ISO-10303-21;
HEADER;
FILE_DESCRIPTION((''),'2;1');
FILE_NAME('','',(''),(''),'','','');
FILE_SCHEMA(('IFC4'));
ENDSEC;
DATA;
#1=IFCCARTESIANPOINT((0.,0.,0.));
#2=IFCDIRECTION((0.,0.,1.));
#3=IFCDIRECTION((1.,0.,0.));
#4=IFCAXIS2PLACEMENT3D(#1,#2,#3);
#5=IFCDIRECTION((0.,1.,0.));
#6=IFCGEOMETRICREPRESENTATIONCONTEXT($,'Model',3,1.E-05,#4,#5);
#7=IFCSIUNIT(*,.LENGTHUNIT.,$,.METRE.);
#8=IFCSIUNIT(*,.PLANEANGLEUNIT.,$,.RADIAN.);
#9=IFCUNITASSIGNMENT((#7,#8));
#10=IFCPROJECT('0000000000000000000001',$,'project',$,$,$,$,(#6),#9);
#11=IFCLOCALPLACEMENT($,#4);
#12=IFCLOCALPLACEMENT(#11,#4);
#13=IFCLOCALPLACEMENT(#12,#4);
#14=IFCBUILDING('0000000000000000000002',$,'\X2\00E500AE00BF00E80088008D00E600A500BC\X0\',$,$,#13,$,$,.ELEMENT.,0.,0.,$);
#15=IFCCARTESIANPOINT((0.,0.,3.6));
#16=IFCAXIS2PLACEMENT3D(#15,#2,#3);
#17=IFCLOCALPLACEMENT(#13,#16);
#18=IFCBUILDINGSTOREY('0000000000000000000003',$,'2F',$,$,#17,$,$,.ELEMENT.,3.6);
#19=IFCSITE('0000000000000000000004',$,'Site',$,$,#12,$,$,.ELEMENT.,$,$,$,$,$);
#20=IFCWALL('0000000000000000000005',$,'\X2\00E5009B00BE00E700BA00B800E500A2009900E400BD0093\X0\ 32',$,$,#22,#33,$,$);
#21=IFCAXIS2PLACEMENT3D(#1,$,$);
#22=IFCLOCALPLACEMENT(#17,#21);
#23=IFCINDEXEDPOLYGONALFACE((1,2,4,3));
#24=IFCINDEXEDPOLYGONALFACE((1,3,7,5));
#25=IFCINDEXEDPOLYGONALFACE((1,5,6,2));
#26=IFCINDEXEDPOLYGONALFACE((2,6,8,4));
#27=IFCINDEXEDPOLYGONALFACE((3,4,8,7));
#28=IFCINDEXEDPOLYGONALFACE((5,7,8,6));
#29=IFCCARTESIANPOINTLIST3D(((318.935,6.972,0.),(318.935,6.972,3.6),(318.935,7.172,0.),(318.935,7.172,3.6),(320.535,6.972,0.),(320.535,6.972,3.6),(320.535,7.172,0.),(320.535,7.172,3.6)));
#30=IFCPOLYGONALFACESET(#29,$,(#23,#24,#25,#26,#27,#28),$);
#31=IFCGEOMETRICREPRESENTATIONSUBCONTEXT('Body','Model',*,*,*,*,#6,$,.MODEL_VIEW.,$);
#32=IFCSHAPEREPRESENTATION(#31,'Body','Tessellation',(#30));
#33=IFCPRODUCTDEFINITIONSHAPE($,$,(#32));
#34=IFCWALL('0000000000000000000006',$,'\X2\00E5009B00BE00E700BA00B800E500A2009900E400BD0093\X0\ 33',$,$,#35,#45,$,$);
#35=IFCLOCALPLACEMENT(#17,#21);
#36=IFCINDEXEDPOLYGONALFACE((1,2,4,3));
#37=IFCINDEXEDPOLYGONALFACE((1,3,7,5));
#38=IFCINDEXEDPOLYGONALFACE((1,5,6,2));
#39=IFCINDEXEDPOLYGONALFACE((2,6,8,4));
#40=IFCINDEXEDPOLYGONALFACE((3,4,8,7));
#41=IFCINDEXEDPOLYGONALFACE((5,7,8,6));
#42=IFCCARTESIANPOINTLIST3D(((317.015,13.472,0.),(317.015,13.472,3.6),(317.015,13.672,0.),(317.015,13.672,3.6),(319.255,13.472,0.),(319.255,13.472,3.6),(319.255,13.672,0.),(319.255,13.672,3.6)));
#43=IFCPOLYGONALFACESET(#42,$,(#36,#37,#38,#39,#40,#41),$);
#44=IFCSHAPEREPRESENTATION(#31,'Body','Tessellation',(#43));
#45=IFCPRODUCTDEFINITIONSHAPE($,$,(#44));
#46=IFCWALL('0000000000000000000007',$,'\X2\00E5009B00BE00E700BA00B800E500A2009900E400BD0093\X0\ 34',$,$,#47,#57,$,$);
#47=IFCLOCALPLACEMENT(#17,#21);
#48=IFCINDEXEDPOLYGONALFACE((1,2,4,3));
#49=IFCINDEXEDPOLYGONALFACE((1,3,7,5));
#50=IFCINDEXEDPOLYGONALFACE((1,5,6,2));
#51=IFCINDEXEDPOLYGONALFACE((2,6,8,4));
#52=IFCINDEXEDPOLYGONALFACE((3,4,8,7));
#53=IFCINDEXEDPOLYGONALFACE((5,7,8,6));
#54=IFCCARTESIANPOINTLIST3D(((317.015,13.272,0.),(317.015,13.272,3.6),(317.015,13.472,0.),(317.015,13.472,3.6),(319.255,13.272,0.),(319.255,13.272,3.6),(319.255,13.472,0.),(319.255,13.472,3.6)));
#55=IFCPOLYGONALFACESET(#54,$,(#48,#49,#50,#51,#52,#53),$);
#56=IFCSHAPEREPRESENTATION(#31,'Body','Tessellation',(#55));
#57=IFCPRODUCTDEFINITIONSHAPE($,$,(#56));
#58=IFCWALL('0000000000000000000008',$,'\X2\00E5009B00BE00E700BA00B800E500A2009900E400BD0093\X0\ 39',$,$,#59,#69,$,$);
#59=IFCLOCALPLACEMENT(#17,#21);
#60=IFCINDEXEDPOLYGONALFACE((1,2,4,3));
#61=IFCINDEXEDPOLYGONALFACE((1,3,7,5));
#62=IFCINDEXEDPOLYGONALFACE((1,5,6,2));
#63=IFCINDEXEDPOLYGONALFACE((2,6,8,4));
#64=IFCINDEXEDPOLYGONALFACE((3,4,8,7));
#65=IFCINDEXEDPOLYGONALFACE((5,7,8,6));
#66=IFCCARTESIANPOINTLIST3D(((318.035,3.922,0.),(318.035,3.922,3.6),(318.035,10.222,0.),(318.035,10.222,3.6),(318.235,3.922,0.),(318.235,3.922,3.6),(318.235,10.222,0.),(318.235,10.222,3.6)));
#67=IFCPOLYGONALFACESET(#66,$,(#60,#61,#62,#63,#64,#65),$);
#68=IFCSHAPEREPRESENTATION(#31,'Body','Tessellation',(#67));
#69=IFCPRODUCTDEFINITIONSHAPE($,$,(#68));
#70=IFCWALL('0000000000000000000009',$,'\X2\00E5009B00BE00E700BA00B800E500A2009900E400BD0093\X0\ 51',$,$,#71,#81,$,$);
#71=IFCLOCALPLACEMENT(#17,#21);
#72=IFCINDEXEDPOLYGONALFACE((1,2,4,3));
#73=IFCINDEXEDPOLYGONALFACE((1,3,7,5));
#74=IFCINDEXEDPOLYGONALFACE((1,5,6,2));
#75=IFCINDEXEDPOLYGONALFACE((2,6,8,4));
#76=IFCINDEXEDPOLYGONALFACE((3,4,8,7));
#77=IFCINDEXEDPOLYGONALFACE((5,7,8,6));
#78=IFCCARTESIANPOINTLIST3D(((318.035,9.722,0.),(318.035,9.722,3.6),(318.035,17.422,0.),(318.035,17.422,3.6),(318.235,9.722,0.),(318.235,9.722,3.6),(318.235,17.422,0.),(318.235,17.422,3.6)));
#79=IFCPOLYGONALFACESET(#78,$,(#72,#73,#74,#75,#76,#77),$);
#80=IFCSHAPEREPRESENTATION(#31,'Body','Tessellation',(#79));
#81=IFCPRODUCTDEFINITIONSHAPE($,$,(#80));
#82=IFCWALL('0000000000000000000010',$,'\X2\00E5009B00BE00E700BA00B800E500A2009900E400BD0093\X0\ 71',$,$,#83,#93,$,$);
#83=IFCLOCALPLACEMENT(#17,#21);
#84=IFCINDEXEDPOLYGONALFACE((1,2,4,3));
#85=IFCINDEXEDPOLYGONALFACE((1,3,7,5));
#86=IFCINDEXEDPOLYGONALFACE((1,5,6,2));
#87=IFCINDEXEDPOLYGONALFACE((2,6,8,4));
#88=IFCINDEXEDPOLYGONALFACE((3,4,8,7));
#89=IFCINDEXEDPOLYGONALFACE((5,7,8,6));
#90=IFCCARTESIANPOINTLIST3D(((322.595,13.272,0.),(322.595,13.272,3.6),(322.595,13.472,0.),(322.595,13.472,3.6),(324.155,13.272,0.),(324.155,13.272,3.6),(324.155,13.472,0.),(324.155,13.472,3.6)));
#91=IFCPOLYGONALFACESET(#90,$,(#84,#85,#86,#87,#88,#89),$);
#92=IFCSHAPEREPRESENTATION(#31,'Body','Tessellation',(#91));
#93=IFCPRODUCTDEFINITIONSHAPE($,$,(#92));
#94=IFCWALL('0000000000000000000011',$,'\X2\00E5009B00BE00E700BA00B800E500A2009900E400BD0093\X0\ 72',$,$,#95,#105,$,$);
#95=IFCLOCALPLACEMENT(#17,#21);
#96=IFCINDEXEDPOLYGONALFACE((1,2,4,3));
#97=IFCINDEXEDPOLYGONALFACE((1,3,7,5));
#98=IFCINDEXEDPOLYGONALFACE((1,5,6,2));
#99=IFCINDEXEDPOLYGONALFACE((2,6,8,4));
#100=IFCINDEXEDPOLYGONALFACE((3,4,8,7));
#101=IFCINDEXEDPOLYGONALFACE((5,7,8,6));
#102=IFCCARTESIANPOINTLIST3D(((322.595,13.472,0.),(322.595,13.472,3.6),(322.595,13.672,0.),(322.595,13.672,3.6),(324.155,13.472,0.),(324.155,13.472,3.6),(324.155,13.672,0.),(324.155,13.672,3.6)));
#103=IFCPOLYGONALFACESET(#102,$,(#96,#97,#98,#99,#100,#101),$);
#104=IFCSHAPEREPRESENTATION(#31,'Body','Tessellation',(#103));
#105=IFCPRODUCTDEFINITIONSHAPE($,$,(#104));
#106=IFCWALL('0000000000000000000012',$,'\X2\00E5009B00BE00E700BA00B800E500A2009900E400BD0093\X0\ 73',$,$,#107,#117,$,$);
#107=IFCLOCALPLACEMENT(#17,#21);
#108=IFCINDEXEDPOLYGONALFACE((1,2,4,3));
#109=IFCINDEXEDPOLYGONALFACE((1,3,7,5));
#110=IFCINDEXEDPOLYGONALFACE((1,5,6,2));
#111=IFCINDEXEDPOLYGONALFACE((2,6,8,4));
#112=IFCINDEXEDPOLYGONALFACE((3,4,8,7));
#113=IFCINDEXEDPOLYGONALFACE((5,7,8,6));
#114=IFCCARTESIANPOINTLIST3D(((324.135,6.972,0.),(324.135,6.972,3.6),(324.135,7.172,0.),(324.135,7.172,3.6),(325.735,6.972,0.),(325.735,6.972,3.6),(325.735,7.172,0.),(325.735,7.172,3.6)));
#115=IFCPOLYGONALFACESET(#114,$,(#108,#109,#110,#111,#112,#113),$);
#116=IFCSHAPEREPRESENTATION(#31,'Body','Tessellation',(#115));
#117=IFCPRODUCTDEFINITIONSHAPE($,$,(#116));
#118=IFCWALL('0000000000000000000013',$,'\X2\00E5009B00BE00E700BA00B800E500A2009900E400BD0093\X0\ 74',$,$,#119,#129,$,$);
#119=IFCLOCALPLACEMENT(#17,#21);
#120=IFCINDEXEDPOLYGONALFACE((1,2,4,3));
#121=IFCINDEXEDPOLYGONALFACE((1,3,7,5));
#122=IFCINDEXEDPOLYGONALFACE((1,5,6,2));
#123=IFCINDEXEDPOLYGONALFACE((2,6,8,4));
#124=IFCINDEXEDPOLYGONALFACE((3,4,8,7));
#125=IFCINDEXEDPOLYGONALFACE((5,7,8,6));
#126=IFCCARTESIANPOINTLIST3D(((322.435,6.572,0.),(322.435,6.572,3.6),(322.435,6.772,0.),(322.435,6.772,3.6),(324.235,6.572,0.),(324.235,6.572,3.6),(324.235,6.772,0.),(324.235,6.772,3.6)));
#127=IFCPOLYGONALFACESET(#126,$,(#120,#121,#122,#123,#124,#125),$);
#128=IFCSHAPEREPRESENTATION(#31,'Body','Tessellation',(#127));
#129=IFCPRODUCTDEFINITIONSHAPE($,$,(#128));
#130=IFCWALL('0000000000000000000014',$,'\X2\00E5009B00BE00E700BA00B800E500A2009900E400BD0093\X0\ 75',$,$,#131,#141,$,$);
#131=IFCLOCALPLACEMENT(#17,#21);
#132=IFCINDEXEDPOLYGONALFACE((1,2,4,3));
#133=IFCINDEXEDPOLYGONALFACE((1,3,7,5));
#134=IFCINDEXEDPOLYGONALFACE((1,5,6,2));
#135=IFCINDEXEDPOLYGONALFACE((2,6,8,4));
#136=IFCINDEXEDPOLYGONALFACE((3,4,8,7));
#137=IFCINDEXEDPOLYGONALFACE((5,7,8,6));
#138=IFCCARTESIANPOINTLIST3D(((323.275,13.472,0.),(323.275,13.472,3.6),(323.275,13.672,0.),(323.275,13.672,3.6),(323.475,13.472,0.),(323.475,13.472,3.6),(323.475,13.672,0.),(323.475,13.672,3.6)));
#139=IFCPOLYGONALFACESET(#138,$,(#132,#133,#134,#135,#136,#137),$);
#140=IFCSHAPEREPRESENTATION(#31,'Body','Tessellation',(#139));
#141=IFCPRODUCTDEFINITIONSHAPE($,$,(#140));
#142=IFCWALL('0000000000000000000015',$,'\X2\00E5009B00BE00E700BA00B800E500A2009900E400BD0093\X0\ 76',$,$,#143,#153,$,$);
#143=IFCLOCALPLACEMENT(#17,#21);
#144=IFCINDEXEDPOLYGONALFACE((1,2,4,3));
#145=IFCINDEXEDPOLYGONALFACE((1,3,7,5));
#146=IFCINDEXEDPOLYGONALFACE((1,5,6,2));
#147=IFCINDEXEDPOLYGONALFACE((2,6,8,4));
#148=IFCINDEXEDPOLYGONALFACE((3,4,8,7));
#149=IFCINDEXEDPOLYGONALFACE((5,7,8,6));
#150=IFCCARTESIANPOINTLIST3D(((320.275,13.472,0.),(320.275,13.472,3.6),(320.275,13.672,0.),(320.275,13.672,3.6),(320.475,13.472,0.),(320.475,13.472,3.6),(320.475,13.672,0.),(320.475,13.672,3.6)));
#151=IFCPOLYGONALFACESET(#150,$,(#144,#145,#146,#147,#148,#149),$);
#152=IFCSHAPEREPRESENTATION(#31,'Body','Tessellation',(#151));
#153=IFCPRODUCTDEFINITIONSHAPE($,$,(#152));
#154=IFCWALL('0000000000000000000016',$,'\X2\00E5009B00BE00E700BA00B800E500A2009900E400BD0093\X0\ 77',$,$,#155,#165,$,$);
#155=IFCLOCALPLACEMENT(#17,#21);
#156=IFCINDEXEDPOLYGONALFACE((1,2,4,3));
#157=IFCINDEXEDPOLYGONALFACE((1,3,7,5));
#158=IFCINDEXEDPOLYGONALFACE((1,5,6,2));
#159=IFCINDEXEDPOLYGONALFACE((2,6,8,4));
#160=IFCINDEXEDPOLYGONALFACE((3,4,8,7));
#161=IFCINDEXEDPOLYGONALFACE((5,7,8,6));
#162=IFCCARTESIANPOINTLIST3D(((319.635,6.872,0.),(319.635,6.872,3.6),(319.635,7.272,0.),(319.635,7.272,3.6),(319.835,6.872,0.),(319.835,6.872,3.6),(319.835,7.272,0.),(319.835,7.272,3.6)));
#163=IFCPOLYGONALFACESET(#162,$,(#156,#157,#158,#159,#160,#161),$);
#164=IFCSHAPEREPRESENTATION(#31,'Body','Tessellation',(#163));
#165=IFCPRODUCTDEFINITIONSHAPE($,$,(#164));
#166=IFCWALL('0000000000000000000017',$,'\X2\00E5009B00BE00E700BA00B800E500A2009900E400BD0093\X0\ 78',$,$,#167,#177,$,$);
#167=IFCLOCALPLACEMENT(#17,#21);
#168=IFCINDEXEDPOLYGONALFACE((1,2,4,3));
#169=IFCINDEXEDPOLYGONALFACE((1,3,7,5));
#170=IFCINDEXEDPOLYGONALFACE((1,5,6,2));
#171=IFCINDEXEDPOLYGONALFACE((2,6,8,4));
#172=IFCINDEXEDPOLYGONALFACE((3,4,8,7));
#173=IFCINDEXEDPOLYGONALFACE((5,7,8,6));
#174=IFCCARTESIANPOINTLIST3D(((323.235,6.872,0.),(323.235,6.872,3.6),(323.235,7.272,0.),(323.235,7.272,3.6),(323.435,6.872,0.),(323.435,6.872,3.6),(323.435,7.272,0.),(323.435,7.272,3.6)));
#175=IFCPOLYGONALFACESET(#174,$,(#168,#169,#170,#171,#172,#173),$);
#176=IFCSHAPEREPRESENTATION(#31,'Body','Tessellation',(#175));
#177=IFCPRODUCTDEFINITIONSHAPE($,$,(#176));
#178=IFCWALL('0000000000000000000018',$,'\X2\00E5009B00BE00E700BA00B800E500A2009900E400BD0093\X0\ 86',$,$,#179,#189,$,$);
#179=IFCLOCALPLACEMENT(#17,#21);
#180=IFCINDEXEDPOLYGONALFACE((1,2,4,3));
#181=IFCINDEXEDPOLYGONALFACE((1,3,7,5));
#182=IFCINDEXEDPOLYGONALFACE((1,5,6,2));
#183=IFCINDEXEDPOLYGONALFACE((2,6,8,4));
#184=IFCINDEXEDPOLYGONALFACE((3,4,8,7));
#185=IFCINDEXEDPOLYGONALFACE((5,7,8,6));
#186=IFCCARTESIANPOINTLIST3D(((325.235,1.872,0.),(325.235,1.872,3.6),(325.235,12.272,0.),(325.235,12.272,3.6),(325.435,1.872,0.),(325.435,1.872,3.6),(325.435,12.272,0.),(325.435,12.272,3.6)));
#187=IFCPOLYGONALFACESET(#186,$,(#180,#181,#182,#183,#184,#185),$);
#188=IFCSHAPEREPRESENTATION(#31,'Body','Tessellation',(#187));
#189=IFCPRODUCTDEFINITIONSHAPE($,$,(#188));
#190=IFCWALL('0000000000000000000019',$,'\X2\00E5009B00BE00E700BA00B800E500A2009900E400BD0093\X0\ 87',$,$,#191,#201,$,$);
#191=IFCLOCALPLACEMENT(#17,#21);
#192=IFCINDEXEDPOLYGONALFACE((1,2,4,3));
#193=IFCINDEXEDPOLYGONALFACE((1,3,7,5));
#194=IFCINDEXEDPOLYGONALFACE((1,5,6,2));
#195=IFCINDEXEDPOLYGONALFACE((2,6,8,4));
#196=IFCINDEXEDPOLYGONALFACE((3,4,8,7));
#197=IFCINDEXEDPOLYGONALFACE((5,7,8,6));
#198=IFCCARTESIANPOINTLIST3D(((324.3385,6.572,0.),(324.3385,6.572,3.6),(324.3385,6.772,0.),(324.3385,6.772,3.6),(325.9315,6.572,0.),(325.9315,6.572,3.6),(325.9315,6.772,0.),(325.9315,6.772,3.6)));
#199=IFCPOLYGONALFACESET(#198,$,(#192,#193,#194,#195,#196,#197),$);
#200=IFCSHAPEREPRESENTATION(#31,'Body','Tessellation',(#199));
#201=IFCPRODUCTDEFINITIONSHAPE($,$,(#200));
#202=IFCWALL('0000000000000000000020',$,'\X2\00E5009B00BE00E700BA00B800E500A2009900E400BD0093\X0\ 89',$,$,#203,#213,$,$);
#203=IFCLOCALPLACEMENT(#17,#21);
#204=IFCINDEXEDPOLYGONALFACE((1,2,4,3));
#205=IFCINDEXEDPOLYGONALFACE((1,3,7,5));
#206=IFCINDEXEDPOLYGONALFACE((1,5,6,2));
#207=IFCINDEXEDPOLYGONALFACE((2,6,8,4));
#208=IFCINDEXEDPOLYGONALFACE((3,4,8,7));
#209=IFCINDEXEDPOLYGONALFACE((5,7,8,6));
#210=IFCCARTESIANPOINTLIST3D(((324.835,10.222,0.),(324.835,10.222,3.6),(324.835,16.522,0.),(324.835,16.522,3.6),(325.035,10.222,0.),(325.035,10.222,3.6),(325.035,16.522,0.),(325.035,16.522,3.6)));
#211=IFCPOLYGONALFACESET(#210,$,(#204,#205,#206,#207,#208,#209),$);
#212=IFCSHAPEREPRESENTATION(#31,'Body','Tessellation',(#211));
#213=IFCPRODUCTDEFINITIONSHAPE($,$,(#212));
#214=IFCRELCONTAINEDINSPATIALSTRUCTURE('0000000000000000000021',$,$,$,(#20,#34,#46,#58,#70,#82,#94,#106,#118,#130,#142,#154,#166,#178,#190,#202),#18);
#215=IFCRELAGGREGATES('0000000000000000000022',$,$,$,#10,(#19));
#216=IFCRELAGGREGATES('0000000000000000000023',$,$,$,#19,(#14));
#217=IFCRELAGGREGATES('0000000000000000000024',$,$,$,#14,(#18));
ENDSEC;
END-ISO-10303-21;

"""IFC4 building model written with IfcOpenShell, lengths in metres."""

from ifc_helpers import new_model, si_unit, direction, frame, frame_2d, origin_with_axes, place, context, subcontext, project, spatial, rectangle, extrude, element, save


model = new_model("IFC4")

# Units and contexts
model_context = context("Model", 3, precision=1e-05, world=origin_with_axes(), true_north=direction((0.0, 1.0, 0.0)))
body_context = subcontext(model_context, "Body", "Model", "MODEL_VIEW")
ifc_project = project(units=[si_unit("LENGTHUNIT", "METRE"), si_unit("PLANEANGLEUNIT", "RADIAN")], contexts=[model_context])

# Site, building, storey
placement = place(None, origin_with_axes())
site_placement = place(placement, origin_with_axes())
site = spatial("IfcSite", under=ifc_project, at=site_placement, Name="Site", CompositionType="ELEMENT")
building_placement = place(site_placement, origin_with_axes())
building = spatial("IfcBuilding", under=site, at=building_placement, Name="å®¿è\u0088\u008dæ¥¼", CompositionType="ELEMENT", ElevationOfRefHeight=0.0, ElevationOfTerrain=0.0)
storey_placement = place(building_placement, frame((0.0, 0.0, 3.6), z_axis=(0.0, 0.0, 1.0), x_axis=(1.0, 0.0, 0.0)))
storey = spatial("IfcBuildingStorey", under=building, at=storey_placement, Name="2F", CompositionType="ELEMENT", Elevation=3.6)

# Walls
wall_1_placement = place(storey_placement, frame((319.735, 7.072, 0.0), z_axis=(0.0, 0.0, 1.0), x_axis=(-1.0, 0.0, 0.0)))
element("IfcWall", 1, at=wall_1_placement, inside=storey, Name="å\u009b¾çº¸å¢\u0099ä½\u0093 32", context=body_context, shape_type="SweptSolid", body=[
    extrude(rectangle(XDim=1.6, YDim=0.2, at=frame_2d((0.0, 0.0), x_axis=(1.0, 0.0, 0.0))), frame((0.0, 0.0, 0.0), z_axis=(0.0, 0.0, 1.0)), (0.0, 0.0, 1.0), 3.6),
])
for number, where, z_axis, x_axis, name in (
    (2, (318.135, 13.572, 0.0), (0.0, 0.0, 1.0), (1.0, 0.0, 0.0), "å\u009b¾çº¸å¢\u0099ä½\u0093 33"),
    (3, (318.135, 13.372, 0.0), (0.0, 0.0, 1.0), (1.0, 0.0, 0.0), "å\u009b¾çº¸å¢\u0099ä½\u0093 34"),
):
    element("IfcWall", number, at=place(storey_placement, frame(where, z_axis=z_axis, x_axis=x_axis)), inside=storey, Name=name, context=body_context, shape_type="SweptSolid", body=[
        extrude(rectangle(XDim=2.24, YDim=0.2, at=frame_2d((0.0, 0.0), x_axis=(1.0, 0.0, 0.0))), frame((0.0, 0.0, 0.0), z_axis=(0.0, 0.0, 1.0)), (0.0, 0.0, 1.0), 3.6),
    ])
wall_2_placement = place(storey_placement, frame((318.135, 7.072, 0.0), z_axis=(0.0, 0.0, 1.0), x_axis=(0.0, 1.0, 0.0)))
element("IfcWall", 4, at=wall_2_placement, inside=storey, Name="å\u009b¾çº¸å¢\u0099ä½\u0093 39", context=body_context, shape_type="SweptSolid", body=[
    extrude(rectangle(XDim=6.3, YDim=0.2, at=frame_2d((0.0, 0.0), x_axis=(1.0, 0.0, 0.0))), frame((0.0, 0.0, 0.0), z_axis=(0.0, 0.0, 1.0)), (0.0, 0.0, 1.0), 3.6),
])
wall_3_placement = place(storey_placement, frame((318.135, 13.572, 0.0), z_axis=(0.0, 0.0, 1.0), x_axis=(0.0, 1.0, 0.0)))
element("IfcWall", 5, at=wall_3_placement, inside=storey, Name="å\u009b¾çº¸å¢\u0099ä½\u0093 51", context=body_context, shape_type="SweptSolid", body=[
    extrude(rectangle(XDim=7.7, YDim=0.2, at=frame_2d((0.0, 0.0), x_axis=(1.0, 0.0, 0.0))), frame((0.0, 0.0, 0.0), z_axis=(0.0, 0.0, 1.0)), (0.0, 0.0, 1.0), 3.6),
])
for number, where, z_axis, x_axis, name in (
    (6, (323.375, 13.372, 0.0), (0.0, 0.0, 1.0), (1.0, 0.0, 0.0), "å\u009b¾çº¸å¢\u0099ä½\u0093 71"),
    (7, (323.375, 13.572, 0.0), (0.0, 0.0, 1.0), (1.0, 0.0, 0.0), "å\u009b¾çº¸å¢\u0099ä½\u0093 72"),
):
    element("IfcWall", number, at=place(storey_placement, frame(where, z_axis=z_axis, x_axis=x_axis)), inside=storey, Name=name, context=body_context, shape_type="SweptSolid", body=[
        extrude(rectangle(XDim=1.56, YDim=0.2, at=frame_2d((0.0, 0.0), x_axis=(1.0, 0.0, 0.0))), frame((0.0, 0.0, 0.0), z_axis=(0.0, 0.0, 1.0)), (0.0, 0.0, 1.0), 3.6),
    ])
wall_4_placement = place(storey_placement, frame((324.935, 7.072, 0.0), z_axis=(0.0, 0.0, 1.0), x_axis=(-1.0, 0.0, 0.0)))
element("IfcWall", 8, at=wall_4_placement, inside=storey, Name="å\u009b¾çº¸å¢\u0099ä½\u0093 73", context=body_context, shape_type="SweptSolid", body=[
    extrude(rectangle(XDim=1.6, YDim=0.2, at=frame_2d((0.0, 0.0), x_axis=(1.0, 0.0, 0.0))), frame((0.0, 0.0, 0.0), z_axis=(0.0, 0.0, 1.0)), (0.0, 0.0, 1.0), 3.6),
])
wall_5_placement = place(storey_placement, frame((323.335, 6.672, 0.0), z_axis=(0.0, 0.0, 1.0), x_axis=(1.0, 0.0, 0.0)))
element("IfcWall", 9, at=wall_5_placement, inside=storey, Name="å\u009b¾çº¸å¢\u0099ä½\u0093 74", context=body_context, shape_type="SweptSolid", body=[
    extrude(rectangle(XDim=1.8, YDim=0.2, at=frame_2d((0.0, 0.0), x_axis=(1.0, 0.0, 0.0))), frame((0.0, 0.0, 0.0), z_axis=(0.0, 0.0, 1.0)), (0.0, 0.0, 1.0), 3.6),
])
for number, where, z_axis, x_axis, name in (
    (10, (323.375, 13.572, 0.0), (0.0, 0.0, 1.0), (0.0, -1.0, 0.0), "å\u009b¾çº¸å¢\u0099ä½\u0093 75"),
    (11, (320.375, 13.572, 0.0), (0.0, 0.0, 1.0), (0.0, -1.0, 0.0), "å\u009b¾çº¸å¢\u0099ä½\u0093 76"),
):
    element("IfcWall", number, at=place(storey_placement, frame(where, z_axis=z_axis, x_axis=x_axis)), inside=storey, Name=name, context=body_context, shape_type="SweptSolid", body=[
        extrude(rectangle(XDim=0.2, YDim=0.2, at=frame_2d((0.0, 0.0), x_axis=(1.0, 0.0, 0.0))), frame((0.0, 0.0, 0.0), z_axis=(0.0, 0.0, 1.0)), (0.0, 0.0, 1.0), 3.6),
    ])
for number, where, z_axis, x_axis, name in (
    (12, (319.735, 7.072, 0.0), (0.0, 0.0, 1.0), (0.0, -1.0, 0.0), "å\u009b¾çº¸å¢\u0099ä½\u0093 77"),
    (13, (323.335, 7.072, 0.0), (0.0, 0.0, 1.0), (0.0, -1.0, 0.0), "å\u009b¾çº¸å¢\u0099ä½\u0093 78"),
):
    element("IfcWall", number, at=place(storey_placement, frame(where, z_axis=z_axis, x_axis=x_axis)), inside=storey, Name=name, context=body_context, shape_type="SweptSolid", body=[
        extrude(rectangle(XDim=0.4, YDim=0.2, at=frame_2d((0.0, 0.0), x_axis=(1.0, 0.0, 0.0))), frame((0.0, 0.0, 0.0), z_axis=(0.0, 0.0, 1.0)), (0.0, 0.0, 1.0), 3.6),
    ])
wall_6_placement = place(storey_placement, frame((325.335, 7.072, 0.0), z_axis=(0.0, 0.0, 1.0), x_axis=(0.0, 1.0, 0.0)))
element("IfcWall", 14, at=wall_6_placement, inside=storey, Name="å\u009b¾çº¸å¢\u0099ä½\u0093 86", context=body_context, shape_type="SweptSolid", body=[
    extrude(rectangle(XDim=10.4, YDim=0.2, at=frame_2d((0.0, 0.0), x_axis=(1.0, 0.0, 0.0))), frame((0.0, 0.0, 0.0), z_axis=(0.0, 0.0, 1.0)), (0.0, 0.0, 1.0), 3.6),
])
wall_7_placement = place(storey_placement, frame((325.135, 6.672, 0.0), z_axis=(0.0, 0.0, 1.0), x_axis=(1.0, 0.0, 0.0)))
element("IfcWall", 15, at=wall_7_placement, inside=storey, Name="å\u009b¾çº¸å¢\u0099ä½\u0093 87", context=body_context, shape_type="SweptSolid", body=[
    extrude(rectangle(XDim=1.593, YDim=0.2, at=frame_2d((0.0, 0.0), x_axis=(1.0, 0.0, 0.0))), frame((0.0, 0.0, 0.0), z_axis=(0.0, 0.0, 1.0)), (0.0, 0.0, 1.0), 3.6),
])
wall_8_placement = place(storey_placement, frame((324.935, 13.372, 0.0), z_axis=(0.0, 0.0, 1.0), x_axis=(0.0, -1.0, 0.0)))
element("IfcWall", 16, at=wall_8_placement, inside=storey, Name="å\u009b¾çº¸å¢\u0099ä½\u0093 89", context=body_context, shape_type="SweptSolid", body=[
    extrude(rectangle(XDim=6.3, YDim=0.2, at=frame_2d((0.0, 0.0), x_axis=(1.0, 0.0, 0.0))), frame((0.0, 0.0, 0.0), z_axis=(0.0, 0.0, 1.0)), (0.0, 0.0, 1.0), 3.6),
])

save(model, "model.ifc")
